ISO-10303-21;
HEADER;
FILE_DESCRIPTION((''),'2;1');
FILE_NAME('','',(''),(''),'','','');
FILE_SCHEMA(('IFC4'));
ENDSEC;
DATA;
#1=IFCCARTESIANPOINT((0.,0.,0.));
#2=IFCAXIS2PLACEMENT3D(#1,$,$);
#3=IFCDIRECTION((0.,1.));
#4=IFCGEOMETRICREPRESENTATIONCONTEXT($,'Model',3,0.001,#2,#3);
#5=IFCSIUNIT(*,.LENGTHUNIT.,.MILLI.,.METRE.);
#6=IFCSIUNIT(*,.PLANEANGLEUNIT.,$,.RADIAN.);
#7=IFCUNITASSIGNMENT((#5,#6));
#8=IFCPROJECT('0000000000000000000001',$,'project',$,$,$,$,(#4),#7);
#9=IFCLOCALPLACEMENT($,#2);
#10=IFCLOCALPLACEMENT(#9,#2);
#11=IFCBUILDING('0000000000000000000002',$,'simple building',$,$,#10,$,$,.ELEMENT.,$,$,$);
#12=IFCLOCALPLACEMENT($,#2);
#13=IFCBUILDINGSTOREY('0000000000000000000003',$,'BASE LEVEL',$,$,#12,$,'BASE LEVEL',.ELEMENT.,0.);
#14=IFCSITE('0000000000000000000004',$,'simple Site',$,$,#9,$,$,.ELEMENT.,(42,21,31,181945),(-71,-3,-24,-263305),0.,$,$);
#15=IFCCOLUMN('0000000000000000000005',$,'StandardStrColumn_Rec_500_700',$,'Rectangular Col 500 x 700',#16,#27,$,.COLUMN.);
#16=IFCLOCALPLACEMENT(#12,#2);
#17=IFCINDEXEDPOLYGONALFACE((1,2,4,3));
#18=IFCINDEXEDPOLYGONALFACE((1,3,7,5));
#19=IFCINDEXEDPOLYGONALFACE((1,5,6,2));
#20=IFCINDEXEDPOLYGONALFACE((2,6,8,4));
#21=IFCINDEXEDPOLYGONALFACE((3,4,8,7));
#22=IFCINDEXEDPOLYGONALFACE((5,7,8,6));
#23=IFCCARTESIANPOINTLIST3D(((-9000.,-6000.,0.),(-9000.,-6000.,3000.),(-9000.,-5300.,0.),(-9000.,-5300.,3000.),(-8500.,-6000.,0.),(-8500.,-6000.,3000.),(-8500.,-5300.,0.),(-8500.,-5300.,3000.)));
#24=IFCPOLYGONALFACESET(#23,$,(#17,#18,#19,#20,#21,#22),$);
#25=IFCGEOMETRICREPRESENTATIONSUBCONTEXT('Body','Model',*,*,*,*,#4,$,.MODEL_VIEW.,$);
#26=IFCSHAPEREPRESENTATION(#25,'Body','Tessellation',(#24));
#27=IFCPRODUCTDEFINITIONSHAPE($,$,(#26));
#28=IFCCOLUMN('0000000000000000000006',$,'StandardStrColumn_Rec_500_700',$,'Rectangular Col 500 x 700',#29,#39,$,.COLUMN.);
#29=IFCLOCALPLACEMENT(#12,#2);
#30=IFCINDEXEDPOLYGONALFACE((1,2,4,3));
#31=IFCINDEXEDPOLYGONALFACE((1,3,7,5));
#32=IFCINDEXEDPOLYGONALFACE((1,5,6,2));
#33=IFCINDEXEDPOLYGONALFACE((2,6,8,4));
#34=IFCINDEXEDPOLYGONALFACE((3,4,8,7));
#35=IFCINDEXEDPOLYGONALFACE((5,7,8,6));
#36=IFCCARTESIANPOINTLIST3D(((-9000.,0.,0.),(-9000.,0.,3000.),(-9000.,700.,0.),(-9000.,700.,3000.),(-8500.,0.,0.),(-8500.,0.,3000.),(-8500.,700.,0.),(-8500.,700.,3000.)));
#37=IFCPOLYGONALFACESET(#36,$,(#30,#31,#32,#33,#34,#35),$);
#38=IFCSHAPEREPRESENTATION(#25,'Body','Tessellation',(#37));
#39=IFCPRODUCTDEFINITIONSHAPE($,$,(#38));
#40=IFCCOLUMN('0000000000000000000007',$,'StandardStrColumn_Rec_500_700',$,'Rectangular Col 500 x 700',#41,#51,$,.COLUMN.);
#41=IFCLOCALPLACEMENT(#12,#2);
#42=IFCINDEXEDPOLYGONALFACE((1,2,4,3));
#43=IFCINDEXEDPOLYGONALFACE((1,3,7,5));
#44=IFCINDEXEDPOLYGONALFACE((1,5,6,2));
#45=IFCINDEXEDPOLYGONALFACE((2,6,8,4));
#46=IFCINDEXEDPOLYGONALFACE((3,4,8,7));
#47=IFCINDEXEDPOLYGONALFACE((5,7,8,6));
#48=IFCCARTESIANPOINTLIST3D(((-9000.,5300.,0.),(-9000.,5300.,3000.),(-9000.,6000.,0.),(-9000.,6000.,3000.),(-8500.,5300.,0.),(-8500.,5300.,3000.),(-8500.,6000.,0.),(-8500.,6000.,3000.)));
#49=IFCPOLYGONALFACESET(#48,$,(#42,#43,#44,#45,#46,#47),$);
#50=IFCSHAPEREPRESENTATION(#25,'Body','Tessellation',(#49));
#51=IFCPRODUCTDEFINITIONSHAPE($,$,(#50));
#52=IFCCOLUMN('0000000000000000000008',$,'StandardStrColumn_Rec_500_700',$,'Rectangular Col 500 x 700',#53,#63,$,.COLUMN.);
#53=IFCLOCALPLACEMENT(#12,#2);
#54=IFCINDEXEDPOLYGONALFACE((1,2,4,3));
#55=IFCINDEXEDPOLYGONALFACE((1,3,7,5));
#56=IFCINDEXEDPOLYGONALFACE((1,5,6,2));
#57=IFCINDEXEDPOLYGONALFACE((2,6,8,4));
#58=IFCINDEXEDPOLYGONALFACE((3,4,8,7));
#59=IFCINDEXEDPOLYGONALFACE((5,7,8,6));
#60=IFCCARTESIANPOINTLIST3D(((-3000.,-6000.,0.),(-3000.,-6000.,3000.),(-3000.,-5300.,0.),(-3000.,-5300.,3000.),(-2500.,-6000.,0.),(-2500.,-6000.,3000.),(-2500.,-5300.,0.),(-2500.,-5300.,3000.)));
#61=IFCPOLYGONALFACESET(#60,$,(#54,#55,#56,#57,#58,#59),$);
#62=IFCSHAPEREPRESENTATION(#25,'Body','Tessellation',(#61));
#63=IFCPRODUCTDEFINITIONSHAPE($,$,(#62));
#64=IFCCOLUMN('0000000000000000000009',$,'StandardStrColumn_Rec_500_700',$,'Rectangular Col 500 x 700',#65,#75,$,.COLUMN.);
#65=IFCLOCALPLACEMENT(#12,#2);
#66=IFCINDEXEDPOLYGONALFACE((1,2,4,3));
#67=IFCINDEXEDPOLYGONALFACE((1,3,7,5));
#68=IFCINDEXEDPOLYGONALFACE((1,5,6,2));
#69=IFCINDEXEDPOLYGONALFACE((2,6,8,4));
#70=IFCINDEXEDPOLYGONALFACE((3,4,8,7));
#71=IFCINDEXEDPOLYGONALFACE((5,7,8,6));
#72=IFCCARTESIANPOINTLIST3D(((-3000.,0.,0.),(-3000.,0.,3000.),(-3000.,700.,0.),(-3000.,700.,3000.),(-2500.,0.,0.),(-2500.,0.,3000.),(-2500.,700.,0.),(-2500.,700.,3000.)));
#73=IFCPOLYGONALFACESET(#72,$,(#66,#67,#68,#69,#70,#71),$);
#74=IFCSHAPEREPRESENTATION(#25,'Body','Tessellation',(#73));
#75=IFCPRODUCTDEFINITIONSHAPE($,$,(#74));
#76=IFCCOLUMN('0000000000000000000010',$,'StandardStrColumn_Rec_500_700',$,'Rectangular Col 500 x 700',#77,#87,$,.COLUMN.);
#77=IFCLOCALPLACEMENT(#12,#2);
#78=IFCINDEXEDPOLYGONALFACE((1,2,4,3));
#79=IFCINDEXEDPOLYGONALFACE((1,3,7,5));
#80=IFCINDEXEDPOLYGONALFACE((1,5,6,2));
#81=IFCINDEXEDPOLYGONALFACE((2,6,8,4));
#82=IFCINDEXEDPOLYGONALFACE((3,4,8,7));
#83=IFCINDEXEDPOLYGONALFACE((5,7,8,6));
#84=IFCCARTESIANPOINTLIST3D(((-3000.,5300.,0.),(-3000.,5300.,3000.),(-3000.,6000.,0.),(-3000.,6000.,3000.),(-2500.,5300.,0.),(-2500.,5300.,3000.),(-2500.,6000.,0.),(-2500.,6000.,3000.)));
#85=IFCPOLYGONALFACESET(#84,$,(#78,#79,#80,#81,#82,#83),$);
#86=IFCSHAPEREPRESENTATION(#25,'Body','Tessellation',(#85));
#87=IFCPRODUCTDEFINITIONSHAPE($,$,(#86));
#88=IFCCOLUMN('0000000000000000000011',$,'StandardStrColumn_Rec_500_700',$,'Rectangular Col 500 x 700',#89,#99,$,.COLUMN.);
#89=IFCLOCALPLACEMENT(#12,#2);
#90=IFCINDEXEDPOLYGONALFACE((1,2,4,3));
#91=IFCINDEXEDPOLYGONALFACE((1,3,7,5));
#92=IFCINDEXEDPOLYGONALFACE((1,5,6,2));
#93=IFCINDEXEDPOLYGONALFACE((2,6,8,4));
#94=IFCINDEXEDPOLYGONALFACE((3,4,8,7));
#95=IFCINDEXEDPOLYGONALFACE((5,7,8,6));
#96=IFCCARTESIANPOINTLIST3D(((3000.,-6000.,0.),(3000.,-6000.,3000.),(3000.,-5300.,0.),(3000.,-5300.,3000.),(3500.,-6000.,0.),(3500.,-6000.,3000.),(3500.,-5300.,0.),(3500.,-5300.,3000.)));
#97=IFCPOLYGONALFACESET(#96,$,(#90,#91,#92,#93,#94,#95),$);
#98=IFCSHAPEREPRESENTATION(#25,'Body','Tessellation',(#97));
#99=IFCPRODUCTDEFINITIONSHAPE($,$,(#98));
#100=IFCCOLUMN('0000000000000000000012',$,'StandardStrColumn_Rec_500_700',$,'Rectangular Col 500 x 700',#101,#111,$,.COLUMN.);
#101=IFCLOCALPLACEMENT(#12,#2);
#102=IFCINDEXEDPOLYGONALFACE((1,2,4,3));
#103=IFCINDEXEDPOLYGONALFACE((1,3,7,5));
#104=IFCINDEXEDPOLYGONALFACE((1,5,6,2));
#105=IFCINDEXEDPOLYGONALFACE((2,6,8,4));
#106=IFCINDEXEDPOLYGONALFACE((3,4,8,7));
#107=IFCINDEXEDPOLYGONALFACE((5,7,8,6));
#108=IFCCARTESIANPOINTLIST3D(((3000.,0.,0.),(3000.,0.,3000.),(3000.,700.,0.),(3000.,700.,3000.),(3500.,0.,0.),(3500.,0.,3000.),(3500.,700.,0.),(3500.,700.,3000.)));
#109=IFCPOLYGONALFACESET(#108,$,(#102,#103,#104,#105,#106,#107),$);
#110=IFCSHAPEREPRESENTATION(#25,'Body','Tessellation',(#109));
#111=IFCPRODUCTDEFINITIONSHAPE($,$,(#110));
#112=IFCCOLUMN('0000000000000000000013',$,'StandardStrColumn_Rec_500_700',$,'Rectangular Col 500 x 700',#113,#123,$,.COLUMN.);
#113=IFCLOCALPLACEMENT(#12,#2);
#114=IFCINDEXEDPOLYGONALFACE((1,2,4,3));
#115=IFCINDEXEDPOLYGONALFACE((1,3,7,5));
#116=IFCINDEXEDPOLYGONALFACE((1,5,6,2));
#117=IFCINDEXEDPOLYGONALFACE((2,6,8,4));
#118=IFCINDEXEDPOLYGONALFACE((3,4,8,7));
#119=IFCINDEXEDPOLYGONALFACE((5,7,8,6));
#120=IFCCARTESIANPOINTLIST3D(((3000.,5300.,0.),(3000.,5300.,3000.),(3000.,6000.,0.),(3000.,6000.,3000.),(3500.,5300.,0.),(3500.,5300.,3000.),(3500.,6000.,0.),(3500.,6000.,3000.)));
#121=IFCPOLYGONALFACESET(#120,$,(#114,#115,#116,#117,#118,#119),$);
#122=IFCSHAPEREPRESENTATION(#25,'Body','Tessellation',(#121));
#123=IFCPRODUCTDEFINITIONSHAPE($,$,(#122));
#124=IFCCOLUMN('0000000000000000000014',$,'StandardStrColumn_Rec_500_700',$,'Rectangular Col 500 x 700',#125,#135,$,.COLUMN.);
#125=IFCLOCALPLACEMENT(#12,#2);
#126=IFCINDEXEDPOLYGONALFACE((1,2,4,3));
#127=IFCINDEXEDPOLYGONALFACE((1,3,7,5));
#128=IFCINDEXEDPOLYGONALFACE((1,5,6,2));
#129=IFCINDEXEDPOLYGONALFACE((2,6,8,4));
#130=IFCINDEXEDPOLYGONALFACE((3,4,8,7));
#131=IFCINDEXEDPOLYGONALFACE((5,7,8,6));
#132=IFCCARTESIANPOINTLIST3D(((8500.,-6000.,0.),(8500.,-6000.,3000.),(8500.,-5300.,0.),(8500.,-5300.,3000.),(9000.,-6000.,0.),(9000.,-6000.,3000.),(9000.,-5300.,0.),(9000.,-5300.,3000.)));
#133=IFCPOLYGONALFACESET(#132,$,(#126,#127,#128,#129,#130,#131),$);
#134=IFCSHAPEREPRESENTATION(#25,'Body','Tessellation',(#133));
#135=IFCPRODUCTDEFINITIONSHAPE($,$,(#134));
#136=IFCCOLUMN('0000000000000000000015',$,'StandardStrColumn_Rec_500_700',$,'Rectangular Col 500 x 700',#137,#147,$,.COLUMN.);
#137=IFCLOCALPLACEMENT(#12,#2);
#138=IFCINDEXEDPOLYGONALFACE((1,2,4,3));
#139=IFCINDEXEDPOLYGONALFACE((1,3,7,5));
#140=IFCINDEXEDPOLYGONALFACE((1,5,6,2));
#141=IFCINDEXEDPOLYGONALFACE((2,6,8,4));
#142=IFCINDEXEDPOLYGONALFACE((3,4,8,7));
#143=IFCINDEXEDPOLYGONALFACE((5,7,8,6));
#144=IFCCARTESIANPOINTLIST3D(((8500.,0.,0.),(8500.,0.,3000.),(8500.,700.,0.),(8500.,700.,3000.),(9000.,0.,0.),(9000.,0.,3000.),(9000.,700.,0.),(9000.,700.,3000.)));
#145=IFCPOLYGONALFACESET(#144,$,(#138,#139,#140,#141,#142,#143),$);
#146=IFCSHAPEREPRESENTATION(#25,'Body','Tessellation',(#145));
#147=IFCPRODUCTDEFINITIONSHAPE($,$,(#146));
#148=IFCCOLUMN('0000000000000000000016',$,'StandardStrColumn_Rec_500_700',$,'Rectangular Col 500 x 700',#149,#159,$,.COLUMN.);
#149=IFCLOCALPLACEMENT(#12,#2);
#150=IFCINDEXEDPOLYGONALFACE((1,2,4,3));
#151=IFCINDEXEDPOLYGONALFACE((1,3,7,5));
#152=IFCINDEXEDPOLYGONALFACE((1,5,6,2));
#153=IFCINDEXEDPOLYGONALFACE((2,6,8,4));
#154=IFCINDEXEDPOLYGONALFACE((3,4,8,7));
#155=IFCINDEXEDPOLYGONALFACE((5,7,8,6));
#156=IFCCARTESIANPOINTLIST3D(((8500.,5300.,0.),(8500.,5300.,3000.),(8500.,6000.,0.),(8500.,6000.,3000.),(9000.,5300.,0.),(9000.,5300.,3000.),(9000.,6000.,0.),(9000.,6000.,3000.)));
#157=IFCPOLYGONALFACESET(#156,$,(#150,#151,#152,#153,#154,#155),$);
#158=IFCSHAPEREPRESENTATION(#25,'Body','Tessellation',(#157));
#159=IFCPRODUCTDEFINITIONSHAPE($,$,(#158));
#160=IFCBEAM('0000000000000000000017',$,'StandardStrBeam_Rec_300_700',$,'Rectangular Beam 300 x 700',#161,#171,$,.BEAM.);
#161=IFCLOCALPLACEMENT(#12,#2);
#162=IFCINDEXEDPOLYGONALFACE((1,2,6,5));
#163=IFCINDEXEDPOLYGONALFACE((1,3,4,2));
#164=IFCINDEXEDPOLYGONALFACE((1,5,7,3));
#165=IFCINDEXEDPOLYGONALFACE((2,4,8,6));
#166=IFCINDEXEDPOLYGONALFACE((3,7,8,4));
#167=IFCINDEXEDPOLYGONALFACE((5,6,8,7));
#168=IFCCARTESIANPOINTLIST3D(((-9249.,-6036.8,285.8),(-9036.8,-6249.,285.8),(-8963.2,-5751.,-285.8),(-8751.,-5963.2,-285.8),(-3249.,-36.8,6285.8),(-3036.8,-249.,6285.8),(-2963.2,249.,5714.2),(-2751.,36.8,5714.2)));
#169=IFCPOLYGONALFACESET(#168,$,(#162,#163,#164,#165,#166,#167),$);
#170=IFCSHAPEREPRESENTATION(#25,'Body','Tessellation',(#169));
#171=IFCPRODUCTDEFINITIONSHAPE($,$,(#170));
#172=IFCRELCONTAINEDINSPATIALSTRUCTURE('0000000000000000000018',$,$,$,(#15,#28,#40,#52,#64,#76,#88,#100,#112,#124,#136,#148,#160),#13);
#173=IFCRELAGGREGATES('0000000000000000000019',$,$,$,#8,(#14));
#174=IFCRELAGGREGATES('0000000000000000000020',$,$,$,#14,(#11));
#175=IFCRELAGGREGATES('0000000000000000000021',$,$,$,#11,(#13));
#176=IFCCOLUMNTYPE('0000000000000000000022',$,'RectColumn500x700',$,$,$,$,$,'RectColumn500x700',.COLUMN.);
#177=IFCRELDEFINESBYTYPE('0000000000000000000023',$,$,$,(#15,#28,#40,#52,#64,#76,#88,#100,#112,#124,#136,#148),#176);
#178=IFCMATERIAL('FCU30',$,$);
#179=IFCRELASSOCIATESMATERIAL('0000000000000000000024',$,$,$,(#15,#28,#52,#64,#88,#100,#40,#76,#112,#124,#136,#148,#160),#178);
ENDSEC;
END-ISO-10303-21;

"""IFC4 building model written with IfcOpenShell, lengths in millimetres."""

from ifc_helpers import new_model, si_unit, direction, frame, origin, origin_with_axes, origin_2d_with_axis, place, context, subcontext, project, spatial, rectangle, extrude, material, material_profile, profile_set, profile_usage, type_object, element, save


model = new_model("IFC4")

# Units and contexts
model_context = context("Model", 3, precision=0.001, world=origin(), true_north=direction((0.0, 1.0)))
body_context = subcontext(model_context, "Body", "Model", "MODEL_VIEW")
ifc_project = project(units=[si_unit("LENGTHUNIT", "METRE", prefix="MILLI"), si_unit("PLANEANGLEUNIT", "RADIAN")], contexts=[model_context])

# Site, building, storey
site_placement = place(None, origin())
site = spatial("IfcSite", under=ifc_project, at=site_placement, Name="simple Site", CompositionType="ELEMENT", RefLatitude=(42, 21, 31, 181945), RefLongitude=(-71, -3, -24, -263305), RefElevation=0.0)
building_placement = place(site_placement, origin())
building = spatial("IfcBuilding", under=site, at=building_placement, Name="simple building", CompositionType="ELEMENT")
storey_placement = place(None, origin())
storey = spatial("IfcBuildingStorey", under=building, at=storey_placement, Name="BASE LEVEL", LongName="BASE LEVEL", CompositionType="ELEMENT", Elevation=0.0)

# Columns
ifc_material = material(Name="FCU30")
ifc_material_profile_1 = material_profile(ifc_material, rectangle(XDim=500.0, YDim=700.0, at=origin_2d_with_axis()))
ifc_profile_set_1 = profile_set([ifc_material_profile_1])
ifc_profile_usage_1 = profile_usage(ifc_profile_set_1, cardinal=7)
column_type = type_object("IfcColumnType", Name="RectColumn500x700", ElementType="RectColumn500x700", PredefinedType="COLUMN")
for number, where, z_axis, x_axis, name in (
    (1, (-8750.0, -5650.0, 0.0), (0.0, 0.0, 1.0), (1.0, 0.0, 0.0), "StandardStrColumn_Rec_500_700"),
    (2, (-8750.0, 350.0, 0.0), (0.0, 0.0, 1.0), (1.0, 0.0, 0.0), "StandardStrColumn_Rec_500_700"),
):
    element("IfcColumn", number, at=place(None, frame(where, z_axis=z_axis, x_axis=x_axis)), inside=storey, type_object=column_type, material=ifc_profile_usage_1, Name=name, ObjectType="Rectangular Col 500 x 700", PredefinedType="COLUMN", context=body_context, shape_type="SweptSolid", body=[
        extrude(rectangle(XDim=500.0, YDim=700.0, at=origin_2d_with_axis()), origin_with_axes(), (0.0, 0.0, 1.0), 3000.0),
    ])
ifc_profile_usage_2 = profile_usage(ifc_profile_set_1, cardinal=1)
column_1_placement = place(None, frame((-8750.0, 5650.0, 0.0), z_axis=(0.0, 0.0, 1.0), x_axis=(1.0, 0.0, 0.0)))
element("IfcColumn", 3, at=column_1_placement, inside=storey, type_object=column_type, material=ifc_profile_usage_2, Name="StandardStrColumn_Rec_500_700", ObjectType="Rectangular Col 500 x 700", PredefinedType="COLUMN", context=body_context, shape_type="SweptSolid", body=[
    extrude(rectangle(XDim=500.0, YDim=700.0, at=origin_2d_with_axis()), origin_with_axes(), (0.0, 0.0, 1.0), 3000.0),
])
for number, where, z_axis, x_axis, name in (
    (4, (-2750.0, -5650.0, 0.0), (0.0, 0.0, 1.0), (1.0, 0.0, 0.0), "StandardStrColumn_Rec_500_700"),
    (5, (-2750.0, 350.0, 0.0), (0.0, 0.0, 1.0), (1.0, 0.0, 0.0), "StandardStrColumn_Rec_500_700"),
):
    element("IfcColumn", number, at=place(None, frame(where, z_axis=z_axis, x_axis=x_axis)), inside=storey, type_object=column_type, material=ifc_profile_usage_1, Name=name, ObjectType="Rectangular Col 500 x 700", PredefinedType="COLUMN", context=body_context, shape_type="SweptSolid", body=[
        extrude(rectangle(XDim=500.0, YDim=700.0, at=origin_2d_with_axis()), origin_with_axes(), (0.0, 0.0, 1.0), 3000.0),
    ])
column_2_placement = place(None, frame((-2750.0, 5650.0, 0.0), z_axis=(0.0, 0.0, 1.0), x_axis=(1.0, 0.0, 0.0)))
element("IfcColumn", 6, at=column_2_placement, inside=storey, type_object=column_type, material=ifc_profile_usage_2, Name="StandardStrColumn_Rec_500_700", ObjectType="Rectangular Col 500 x 700", PredefinedType="COLUMN", context=body_context, shape_type="SweptSolid", body=[
    extrude(rectangle(XDim=500.0, YDim=700.0, at=origin_2d_with_axis()), origin_with_axes(), (0.0, 0.0, 1.0), 3000.0),
])
for number, where, z_axis, x_axis, name in (
    (7, (3250.0, -5650.0, 0.0), (0.0, 0.0, 1.0), (1.0, 0.0, 0.0), "StandardStrColumn_Rec_500_700"),
    (8, (3250.0, 350.0, 0.0), (0.0, 0.0, 1.0), (1.0, 0.0, 0.0), "StandardStrColumn_Rec_500_700"),
):
    element("IfcColumn", number, at=place(None, frame(where, z_axis=z_axis, x_axis=x_axis)), inside=storey, type_object=column_type, material=ifc_profile_usage_1, Name=name, ObjectType="Rectangular Col 500 x 700", PredefinedType="COLUMN", context=body_context, shape_type="SweptSolid", body=[
        extrude(rectangle(XDim=500.0, YDim=700.0, at=origin_2d_with_axis()), origin_with_axes(), (0.0, 0.0, 1.0), 3000.0),
    ])
column_3_placement = place(None, frame((3250.0, 5650.0, 0.0), z_axis=(0.0, 0.0, 1.0), x_axis=(1.0, 0.0, 0.0)))
element("IfcColumn", 9, at=column_3_placement, inside=storey, type_object=column_type, material=ifc_profile_usage_2, Name="StandardStrColumn_Rec_500_700", ObjectType="Rectangular Col 500 x 700", PredefinedType="COLUMN", context=body_context, shape_type="SweptSolid", body=[
    extrude(rectangle(XDim=500.0, YDim=700.0, at=origin_2d_with_axis()), origin_with_axes(), (0.0, 0.0, 1.0), 3000.0),
])
ifc_profile_usage_3 = profile_usage(ifc_profile_set_1, cardinal=9)
for number, where, z_axis, x_axis, name in (
    (10, (8750.0, -5650.0, 0.0), (0.0, 0.0, 1.0), (1.0, 0.0, 0.0), "StandardStrColumn_Rec_500_700"),
    (11, (8750.0, 350.0, 0.0), (0.0, 0.0, 1.0), (1.0, 0.0, 0.0), "StandardStrColumn_Rec_500_700"),
):
    element("IfcColumn", number, at=place(None, frame(where, z_axis=z_axis, x_axis=x_axis)), inside=storey, type_object=column_type, material=ifc_profile_usage_3, Name=name, ObjectType="Rectangular Col 500 x 700", PredefinedType="COLUMN", context=body_context, shape_type="SweptSolid", body=[
        extrude(rectangle(XDim=500.0, YDim=700.0, at=origin_2d_with_axis()), origin_with_axes(), (0.0, 0.0, 1.0), 3000.0),
    ])
ifc_profile_usage_4 = profile_usage(ifc_profile_set_1, cardinal=3)
column_4_placement = place(None, frame((8750.0, 5650.0, 0.0), z_axis=(0.0, 0.0, 1.0), x_axis=(1.0, 0.0, 0.0)))
element("IfcColumn", 12, at=column_4_placement, inside=storey, type_object=column_type, material=ifc_profile_usage_4, Name="StandardStrColumn_Rec_500_700", ObjectType="Rectangular Col 500 x 700", PredefinedType="COLUMN", context=body_context, shape_type="SweptSolid", body=[
    extrude(rectangle(XDim=500.0, YDim=700.0, at=origin_2d_with_axis()), origin_with_axes(), (0.0, 0.0, 1.0), 3000.0),
])

# Beam
ifc_material_profile_2 = material_profile(ifc_material, rectangle(XDim=300.0, YDim=700.0, at=origin_2d_with_axis()))
ifc_profile_set_2 = profile_set([ifc_material_profile_2])
ifc_profile_usage_5 = profile_usage(ifc_profile_set_2, cardinal=5)
beam_placement = place(None, frame((-9000.0, -6000.0, 0.0), z_axis=(0.57735, 0.57735, 0.57735), x_axis=(0.707107, -0.707107, 0.0)))
element("IfcBeam", 13, at=beam_placement, inside=storey, material=ifc_profile_usage_5, Name="StandardStrBeam_Rec_300_700", ObjectType="Rectangular Beam 300 x 700", PredefinedType="BEAM", context=body_context, shape_type="SweptSolid", body=[
    extrude(rectangle(XDim=300.0, YDim=700.0, at=origin_2d_with_axis()), origin_with_axes(), (0.0, 0.0, 1.0), 10392.3),
])

save(model, "model.ifc")
